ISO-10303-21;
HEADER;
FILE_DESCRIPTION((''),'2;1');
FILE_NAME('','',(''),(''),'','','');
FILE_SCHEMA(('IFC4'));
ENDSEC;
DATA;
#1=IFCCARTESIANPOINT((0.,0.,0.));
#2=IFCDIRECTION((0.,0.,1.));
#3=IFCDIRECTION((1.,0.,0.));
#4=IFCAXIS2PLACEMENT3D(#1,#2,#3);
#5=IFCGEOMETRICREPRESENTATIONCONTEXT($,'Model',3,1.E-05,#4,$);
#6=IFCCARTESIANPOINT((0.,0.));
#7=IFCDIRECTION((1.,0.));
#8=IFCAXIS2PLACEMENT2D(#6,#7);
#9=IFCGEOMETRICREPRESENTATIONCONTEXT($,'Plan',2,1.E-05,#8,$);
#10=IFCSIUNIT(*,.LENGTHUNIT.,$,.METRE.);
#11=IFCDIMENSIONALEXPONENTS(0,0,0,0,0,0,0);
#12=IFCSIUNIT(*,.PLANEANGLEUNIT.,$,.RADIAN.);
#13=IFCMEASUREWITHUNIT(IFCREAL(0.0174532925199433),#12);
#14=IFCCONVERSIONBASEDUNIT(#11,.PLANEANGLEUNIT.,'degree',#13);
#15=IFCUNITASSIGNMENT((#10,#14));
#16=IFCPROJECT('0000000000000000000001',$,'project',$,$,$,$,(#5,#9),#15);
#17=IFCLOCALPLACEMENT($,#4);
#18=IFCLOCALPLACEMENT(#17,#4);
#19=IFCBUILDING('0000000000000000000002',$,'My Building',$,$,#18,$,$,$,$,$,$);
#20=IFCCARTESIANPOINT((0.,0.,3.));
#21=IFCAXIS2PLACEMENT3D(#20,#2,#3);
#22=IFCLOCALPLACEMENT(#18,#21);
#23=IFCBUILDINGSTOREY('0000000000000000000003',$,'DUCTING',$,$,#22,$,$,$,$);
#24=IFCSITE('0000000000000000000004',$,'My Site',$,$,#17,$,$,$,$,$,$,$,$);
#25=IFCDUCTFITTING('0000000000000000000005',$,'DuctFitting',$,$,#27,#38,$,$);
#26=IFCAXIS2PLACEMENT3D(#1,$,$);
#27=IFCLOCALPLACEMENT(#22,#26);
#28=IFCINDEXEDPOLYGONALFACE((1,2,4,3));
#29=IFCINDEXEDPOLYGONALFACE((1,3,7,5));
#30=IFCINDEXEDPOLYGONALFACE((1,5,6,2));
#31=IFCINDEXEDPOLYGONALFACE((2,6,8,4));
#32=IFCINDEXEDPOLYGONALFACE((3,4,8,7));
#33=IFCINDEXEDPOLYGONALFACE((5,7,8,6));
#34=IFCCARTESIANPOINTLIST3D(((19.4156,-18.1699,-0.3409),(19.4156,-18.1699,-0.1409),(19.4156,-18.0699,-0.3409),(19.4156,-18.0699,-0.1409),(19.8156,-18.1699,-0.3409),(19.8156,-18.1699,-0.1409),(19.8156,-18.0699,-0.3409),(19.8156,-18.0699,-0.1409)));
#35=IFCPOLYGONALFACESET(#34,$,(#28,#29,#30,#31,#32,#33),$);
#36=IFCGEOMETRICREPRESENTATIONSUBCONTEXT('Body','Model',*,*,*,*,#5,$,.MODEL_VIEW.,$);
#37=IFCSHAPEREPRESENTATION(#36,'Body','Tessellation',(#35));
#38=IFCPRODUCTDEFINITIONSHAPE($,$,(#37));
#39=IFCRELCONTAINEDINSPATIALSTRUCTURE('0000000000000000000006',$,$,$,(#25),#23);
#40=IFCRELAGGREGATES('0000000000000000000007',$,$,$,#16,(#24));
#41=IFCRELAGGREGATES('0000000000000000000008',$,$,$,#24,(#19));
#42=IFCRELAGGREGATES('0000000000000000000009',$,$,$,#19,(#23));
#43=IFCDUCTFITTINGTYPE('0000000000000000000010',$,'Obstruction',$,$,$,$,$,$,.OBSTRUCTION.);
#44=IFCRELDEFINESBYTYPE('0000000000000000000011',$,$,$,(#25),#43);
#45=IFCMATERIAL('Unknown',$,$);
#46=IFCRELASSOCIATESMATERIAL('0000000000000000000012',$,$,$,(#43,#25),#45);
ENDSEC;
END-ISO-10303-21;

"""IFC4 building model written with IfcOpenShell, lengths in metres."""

from ifc_helpers import new_model, entity, si_unit, converted_unit, frame, origin_with_axes, origin_2d_with_axis, place, context, subcontext, project, spatial, rectangle, extrude, material, material_profile, profile_set, profile_usage, type_object, element, save


model = new_model("IFC4")

# Units and contexts
model_context = context("Model", 3, precision=1e-05, world=origin_with_axes())
plan_context = context("Plan", 2, precision=1e-05, world=origin_2d_with_axis())
body_context = subcontext(model_context, "Body", "Model", "MODEL_VIEW")
ifc_project = project(units=[si_unit("LENGTHUNIT", "METRE"), converted_unit("PLANEANGLEUNIT", "degree", entity("IfcReal", 0.0174532925199433), si_unit("PLANEANGLEUNIT", "RADIAN"), dimensions=[0, 0, 0, 0, 0, 0, 0])], contexts=[model_context, plan_context])

# Site, building, storey
site_placement = place(None, origin_with_axes())
site = spatial("IfcSite", under=ifc_project, at=site_placement, Name="My Site")
building_placement = place(site_placement, origin_with_axes())
building = spatial("IfcBuilding", under=site, at=building_placement, Name="My Building")
storey_placement = place(building_placement, frame((0.0, 0.0, 3.0), z_axis=(0.0, 0.0, 1.0), x_axis=(1.0, 0.0, 0.0)))
storey = spatial("IfcBuildingStorey", under=building, at=storey_placement, Name="DUCTING")

# Shared definitions
ifc_material = material(Name="Unknown")

# Duct fitting
ifc_material_profile_1 = material_profile(ifc_material, rectangle(XDim=0.4, YDim=0.2))
ifc_profile_set_1 = profile_set([ifc_material_profile_1])
duct_fitting_type_1 = type_object("IfcDuctFittingType", Name="Obstruction", PredefinedType="OBSTRUCTION", material=ifc_profile_set_1)
ifc_profile_usage_1 = profile_usage(ifc_profile_set_1, cardinal=5)
duct_fitting_1_placement = place(storey_placement, frame((19.6156, -18.0699, -0.2409), z_axis=(0.0, -1.0, 0.0), x_axis=(1.0, 0.0, 0.0)))
element("IfcDuctFitting", 1, at=duct_fitting_1_placement, inside=storey, type_object=duct_fitting_type_1, material=ifc_profile_usage_1, Name="DuctFitting", context=body_context, shape_type="SweptSolid", body=[
    extrude(rectangle(XDim=0.4, YDim=0.2), origin_with_axes(), (0.0, 0.0, 1.0), 0.1),
])

save(model, "model.ifc")
